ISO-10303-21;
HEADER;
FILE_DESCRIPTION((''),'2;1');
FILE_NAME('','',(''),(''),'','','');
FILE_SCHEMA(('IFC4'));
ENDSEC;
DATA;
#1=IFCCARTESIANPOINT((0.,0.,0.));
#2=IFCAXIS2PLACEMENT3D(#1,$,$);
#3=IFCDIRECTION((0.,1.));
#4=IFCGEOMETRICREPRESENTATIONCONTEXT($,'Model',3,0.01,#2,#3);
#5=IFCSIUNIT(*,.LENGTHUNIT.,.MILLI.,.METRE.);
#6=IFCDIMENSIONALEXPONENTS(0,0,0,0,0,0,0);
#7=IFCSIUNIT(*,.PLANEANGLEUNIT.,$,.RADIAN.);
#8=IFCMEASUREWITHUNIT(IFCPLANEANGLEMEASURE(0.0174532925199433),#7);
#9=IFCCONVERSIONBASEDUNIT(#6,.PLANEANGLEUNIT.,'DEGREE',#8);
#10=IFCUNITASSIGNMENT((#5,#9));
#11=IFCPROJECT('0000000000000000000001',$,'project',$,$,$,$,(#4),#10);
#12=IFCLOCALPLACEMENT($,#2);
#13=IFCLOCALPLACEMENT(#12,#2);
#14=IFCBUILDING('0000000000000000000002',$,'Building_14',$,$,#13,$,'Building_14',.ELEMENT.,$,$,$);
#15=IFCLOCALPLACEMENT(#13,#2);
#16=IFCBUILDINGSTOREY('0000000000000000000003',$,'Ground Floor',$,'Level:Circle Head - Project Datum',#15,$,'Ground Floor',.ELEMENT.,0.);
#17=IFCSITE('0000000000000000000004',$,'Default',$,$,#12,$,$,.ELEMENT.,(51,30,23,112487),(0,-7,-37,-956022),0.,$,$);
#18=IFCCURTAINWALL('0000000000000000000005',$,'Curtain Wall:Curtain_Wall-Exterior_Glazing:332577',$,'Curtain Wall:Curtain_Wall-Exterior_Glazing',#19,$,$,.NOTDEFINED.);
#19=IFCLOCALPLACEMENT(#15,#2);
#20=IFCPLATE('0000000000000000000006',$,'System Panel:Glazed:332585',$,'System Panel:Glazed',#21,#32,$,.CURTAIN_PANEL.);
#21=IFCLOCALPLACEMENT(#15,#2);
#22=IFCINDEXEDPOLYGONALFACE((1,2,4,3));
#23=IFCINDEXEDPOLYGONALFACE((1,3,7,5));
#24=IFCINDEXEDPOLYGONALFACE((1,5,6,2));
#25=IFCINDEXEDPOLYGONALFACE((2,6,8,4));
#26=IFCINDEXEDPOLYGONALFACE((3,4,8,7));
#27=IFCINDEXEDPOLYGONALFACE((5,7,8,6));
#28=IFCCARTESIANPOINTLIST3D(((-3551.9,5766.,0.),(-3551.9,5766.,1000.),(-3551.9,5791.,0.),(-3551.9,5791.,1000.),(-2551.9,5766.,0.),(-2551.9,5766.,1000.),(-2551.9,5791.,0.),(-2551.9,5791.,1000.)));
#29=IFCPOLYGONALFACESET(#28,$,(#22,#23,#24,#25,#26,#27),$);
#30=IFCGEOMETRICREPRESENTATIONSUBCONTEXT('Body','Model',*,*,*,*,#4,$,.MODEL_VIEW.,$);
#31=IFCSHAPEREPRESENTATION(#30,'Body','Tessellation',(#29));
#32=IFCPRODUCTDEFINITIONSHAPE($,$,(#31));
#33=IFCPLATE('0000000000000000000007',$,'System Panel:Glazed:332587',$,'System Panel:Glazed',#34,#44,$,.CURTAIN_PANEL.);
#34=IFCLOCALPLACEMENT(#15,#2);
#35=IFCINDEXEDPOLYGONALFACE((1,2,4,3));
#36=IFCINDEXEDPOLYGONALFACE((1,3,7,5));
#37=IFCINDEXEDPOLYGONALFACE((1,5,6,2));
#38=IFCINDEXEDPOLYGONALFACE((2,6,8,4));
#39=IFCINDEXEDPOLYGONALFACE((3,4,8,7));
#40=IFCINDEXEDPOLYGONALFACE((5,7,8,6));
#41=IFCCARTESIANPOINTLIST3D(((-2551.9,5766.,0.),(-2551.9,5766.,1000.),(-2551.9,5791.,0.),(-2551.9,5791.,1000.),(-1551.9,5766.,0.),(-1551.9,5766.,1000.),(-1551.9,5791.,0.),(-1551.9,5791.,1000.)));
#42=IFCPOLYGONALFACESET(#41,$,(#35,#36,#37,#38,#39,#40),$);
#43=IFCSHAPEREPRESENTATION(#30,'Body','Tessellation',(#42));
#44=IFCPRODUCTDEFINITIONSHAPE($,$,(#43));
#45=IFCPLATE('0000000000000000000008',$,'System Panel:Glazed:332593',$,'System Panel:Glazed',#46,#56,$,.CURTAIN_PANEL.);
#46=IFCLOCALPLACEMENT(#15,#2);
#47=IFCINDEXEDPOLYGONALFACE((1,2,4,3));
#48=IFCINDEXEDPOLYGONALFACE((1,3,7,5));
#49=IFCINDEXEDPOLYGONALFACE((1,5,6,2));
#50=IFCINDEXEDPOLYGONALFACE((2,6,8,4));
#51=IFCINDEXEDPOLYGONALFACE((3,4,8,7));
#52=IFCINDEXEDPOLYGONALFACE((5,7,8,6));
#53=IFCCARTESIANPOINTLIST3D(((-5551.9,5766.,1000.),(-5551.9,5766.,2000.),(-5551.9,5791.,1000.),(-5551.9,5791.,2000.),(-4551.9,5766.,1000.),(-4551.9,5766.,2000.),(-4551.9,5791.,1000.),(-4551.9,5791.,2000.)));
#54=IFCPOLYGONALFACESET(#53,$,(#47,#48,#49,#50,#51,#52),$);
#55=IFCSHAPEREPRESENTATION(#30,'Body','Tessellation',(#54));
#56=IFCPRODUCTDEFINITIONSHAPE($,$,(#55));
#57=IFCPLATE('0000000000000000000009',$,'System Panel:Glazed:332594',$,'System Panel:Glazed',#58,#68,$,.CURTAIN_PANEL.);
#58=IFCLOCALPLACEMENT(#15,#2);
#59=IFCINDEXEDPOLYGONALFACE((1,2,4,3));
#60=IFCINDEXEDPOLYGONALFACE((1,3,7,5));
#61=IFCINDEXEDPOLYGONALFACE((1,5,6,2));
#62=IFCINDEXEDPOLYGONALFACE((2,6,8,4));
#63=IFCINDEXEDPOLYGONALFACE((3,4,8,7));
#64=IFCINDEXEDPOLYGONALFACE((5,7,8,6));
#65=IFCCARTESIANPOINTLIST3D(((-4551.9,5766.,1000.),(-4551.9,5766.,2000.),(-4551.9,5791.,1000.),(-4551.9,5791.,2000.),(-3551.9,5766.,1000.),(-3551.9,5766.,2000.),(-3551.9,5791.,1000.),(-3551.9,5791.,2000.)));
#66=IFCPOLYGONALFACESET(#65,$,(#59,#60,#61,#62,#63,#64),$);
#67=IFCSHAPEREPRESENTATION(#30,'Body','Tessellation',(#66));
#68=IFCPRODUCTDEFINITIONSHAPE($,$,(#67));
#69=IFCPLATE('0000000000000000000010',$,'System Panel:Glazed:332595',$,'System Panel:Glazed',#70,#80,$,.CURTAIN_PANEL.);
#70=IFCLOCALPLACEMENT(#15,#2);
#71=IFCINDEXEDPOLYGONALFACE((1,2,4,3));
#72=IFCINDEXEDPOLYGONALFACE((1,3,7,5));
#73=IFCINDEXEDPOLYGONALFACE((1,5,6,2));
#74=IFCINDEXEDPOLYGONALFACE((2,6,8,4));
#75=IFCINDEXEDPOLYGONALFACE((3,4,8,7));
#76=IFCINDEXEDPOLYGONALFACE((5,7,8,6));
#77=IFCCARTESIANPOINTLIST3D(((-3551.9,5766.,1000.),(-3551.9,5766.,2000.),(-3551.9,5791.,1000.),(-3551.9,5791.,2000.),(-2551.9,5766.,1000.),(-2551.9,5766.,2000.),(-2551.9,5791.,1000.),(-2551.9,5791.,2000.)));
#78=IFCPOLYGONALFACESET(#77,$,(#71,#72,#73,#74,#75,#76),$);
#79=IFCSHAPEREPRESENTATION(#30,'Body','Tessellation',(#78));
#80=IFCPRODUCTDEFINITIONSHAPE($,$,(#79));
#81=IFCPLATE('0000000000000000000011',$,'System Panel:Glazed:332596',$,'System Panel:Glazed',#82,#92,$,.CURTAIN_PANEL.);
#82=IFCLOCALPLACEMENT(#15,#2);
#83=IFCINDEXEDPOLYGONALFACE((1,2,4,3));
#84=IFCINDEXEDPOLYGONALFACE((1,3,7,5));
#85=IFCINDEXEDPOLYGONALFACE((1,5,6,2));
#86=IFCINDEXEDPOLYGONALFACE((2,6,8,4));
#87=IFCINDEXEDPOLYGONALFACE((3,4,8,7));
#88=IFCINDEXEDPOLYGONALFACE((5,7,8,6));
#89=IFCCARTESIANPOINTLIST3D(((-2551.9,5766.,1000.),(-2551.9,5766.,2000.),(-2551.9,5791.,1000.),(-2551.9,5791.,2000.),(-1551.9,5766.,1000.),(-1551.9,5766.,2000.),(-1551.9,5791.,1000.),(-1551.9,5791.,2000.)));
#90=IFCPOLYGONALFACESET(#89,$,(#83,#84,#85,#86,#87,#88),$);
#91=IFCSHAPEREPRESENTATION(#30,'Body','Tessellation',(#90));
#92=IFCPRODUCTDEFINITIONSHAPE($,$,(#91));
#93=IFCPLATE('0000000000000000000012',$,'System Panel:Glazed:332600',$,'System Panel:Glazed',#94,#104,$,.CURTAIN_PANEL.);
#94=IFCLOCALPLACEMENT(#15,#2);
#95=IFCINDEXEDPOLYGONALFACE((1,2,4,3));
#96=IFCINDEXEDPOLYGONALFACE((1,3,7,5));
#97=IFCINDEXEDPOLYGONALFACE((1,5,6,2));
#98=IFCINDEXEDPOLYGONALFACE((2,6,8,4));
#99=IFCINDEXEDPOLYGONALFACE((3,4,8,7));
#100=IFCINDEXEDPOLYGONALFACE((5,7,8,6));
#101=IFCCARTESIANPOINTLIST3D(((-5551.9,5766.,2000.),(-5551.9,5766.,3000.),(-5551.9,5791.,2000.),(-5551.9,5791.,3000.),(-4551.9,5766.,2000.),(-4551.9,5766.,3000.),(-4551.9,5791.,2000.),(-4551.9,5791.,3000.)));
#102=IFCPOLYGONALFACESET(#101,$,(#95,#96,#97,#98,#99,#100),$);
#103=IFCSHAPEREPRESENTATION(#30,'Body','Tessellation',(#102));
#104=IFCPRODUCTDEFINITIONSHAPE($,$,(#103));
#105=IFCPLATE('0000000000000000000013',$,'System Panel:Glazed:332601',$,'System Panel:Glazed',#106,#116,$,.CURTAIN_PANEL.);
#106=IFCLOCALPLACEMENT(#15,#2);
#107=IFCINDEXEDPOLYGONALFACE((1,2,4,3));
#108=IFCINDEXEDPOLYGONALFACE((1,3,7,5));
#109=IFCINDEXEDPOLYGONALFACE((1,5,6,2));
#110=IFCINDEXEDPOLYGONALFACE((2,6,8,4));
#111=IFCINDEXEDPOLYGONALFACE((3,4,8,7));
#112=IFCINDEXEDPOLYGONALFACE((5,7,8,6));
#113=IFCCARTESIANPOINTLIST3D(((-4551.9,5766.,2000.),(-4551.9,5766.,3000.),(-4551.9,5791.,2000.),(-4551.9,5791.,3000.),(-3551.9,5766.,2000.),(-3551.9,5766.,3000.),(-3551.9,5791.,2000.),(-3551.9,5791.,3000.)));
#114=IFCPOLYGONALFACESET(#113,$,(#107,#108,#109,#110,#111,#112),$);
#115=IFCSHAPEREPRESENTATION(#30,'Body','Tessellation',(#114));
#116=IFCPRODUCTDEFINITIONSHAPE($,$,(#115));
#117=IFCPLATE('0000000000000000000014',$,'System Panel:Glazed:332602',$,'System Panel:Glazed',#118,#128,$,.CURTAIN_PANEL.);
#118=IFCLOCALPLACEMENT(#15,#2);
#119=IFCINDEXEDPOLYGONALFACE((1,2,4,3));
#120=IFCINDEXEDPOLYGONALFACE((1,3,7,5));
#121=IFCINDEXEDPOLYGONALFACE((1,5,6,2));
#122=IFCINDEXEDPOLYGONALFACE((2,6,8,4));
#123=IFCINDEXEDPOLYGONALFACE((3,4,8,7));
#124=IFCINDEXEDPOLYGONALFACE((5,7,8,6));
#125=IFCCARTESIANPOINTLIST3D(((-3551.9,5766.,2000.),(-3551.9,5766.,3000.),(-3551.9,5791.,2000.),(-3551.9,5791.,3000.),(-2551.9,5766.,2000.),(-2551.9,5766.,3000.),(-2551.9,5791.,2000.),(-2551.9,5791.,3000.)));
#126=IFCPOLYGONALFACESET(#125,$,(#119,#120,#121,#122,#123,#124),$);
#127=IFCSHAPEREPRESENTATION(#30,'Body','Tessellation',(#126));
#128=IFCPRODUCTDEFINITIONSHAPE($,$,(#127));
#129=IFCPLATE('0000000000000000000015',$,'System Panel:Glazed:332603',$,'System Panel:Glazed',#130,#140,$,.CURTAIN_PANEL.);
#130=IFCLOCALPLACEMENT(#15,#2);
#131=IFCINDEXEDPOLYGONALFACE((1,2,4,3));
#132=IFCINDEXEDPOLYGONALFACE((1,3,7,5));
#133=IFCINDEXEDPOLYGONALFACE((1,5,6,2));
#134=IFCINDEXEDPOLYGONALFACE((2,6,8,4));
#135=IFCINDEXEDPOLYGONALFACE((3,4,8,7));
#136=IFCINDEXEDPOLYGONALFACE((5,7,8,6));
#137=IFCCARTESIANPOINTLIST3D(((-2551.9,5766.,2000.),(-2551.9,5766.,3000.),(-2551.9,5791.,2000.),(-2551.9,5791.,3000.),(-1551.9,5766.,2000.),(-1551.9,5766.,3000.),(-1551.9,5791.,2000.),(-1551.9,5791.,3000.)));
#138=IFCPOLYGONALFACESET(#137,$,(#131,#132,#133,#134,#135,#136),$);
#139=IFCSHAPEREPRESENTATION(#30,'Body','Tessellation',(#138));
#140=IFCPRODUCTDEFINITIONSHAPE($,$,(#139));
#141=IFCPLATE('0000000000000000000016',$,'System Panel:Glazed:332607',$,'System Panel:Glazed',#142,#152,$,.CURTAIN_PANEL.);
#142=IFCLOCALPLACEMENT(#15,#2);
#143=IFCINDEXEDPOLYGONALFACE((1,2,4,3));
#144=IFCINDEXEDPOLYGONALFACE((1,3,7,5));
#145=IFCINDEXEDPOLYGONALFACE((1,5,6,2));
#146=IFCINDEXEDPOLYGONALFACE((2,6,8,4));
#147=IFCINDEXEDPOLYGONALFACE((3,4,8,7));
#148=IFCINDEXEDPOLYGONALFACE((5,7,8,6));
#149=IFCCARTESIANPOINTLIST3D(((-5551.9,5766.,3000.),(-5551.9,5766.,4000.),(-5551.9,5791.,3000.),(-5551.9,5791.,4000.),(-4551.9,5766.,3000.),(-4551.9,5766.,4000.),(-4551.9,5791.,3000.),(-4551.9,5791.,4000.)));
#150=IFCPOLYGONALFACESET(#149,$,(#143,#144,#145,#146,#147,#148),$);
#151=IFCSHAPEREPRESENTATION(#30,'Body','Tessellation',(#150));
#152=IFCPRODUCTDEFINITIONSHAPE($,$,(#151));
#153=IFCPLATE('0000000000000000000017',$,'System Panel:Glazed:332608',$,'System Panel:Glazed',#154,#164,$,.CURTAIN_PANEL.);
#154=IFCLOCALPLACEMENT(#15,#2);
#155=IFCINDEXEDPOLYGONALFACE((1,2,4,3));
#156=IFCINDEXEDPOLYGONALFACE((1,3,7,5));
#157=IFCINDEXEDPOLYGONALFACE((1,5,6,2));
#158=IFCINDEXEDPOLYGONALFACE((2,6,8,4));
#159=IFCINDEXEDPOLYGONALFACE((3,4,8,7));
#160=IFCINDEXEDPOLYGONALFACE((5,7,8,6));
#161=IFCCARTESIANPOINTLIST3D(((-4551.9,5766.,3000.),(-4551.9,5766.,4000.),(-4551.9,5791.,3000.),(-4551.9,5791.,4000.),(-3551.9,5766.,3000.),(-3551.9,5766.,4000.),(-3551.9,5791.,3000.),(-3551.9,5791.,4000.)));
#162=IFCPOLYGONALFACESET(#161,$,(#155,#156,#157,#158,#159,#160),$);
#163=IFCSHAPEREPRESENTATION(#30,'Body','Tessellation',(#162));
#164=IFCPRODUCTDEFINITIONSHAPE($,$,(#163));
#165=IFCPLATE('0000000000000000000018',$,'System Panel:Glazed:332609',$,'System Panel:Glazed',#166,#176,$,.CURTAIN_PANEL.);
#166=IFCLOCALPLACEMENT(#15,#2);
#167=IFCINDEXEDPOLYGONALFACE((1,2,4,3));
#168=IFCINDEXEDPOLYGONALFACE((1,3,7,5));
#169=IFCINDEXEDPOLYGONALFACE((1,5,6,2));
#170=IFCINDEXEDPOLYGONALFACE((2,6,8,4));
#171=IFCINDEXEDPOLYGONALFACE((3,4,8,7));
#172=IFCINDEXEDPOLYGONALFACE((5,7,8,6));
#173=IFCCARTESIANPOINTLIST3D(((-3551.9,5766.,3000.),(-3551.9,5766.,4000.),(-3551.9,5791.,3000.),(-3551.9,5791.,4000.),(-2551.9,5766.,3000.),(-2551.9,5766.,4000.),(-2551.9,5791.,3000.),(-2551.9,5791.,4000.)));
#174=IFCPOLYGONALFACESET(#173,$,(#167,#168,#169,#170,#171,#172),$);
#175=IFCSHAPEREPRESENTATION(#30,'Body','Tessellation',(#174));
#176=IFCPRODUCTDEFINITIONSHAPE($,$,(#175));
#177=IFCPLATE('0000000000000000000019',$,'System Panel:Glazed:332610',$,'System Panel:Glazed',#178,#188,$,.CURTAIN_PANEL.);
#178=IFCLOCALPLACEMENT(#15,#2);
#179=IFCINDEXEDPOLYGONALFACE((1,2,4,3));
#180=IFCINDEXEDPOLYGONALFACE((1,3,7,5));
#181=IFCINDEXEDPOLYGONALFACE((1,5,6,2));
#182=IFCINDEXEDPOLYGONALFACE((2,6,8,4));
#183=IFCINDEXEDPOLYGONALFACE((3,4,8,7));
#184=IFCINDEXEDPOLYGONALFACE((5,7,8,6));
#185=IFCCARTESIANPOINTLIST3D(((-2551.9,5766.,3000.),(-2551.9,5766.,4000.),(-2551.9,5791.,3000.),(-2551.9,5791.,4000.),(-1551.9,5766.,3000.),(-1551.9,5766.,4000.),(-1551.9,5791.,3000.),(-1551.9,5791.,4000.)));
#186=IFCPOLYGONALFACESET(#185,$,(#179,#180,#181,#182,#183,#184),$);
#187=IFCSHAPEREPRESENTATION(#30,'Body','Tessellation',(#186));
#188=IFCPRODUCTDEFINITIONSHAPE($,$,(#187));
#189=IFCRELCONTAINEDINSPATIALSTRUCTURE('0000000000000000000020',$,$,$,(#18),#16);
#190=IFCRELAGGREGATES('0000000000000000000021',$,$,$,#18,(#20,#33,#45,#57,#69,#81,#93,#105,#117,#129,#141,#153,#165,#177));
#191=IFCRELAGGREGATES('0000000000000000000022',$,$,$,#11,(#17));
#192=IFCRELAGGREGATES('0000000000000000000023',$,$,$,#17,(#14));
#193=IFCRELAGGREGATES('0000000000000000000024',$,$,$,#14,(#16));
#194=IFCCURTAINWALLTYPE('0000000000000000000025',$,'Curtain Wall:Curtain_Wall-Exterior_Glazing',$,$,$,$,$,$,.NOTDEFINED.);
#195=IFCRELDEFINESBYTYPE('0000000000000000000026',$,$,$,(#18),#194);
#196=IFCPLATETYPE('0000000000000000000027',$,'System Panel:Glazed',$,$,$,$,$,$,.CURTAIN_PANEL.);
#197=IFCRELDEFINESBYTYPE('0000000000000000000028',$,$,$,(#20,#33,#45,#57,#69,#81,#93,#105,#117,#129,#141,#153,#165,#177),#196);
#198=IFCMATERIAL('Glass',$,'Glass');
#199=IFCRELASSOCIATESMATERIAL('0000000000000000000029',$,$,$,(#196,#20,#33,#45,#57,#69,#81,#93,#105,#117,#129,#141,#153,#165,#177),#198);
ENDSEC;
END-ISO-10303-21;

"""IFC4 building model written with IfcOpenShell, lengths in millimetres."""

from ifc_helpers import new_model, entity, si_unit, converted_unit, direction, frame, origin, place, context, subcontext, project, spatial, indexed_curve, outline, extrude, source, transform, mapped, material, type_object, type_shapes, element, aggregate, save


model = new_model("IFC4")

# Units and contexts
model_context = context("Model", 3, precision=0.01, world=origin(), true_north=direction((0.0, 1.0)))
body_context = subcontext(model_context, "Body", "Model", "MODEL_VIEW")
ifc_project = project(units=[si_unit("LENGTHUNIT", "METRE", prefix="MILLI"), converted_unit("PLANEANGLEUNIT", "DEGREE", entity("IfcPlaneAngleMeasure", 0.0174532925199433), si_unit("PLANEANGLEUNIT", "RADIAN"), dimensions=[0, 0, 0, 0, 0, 0, 0])], contexts=[model_context])

# Site, building, storey
site_placement = place(None, origin())
site = spatial("IfcSite", under=ifc_project, at=site_placement, Name="Default", CompositionType="ELEMENT", RefLatitude=(51, 30, 23, 112487), RefLongitude=(0, -7, -37, -956022), RefElevation=0.0)
building_placement = place(site_placement, origin())
building = spatial("IfcBuilding", under=site, at=building_placement, Name="Building_14", LongName="Building_14", CompositionType="ELEMENT")
storey_placement = place(building_placement, origin())
storey = spatial("IfcBuildingStorey", under=building, at=storey_placement, Name="Ground Floor", ObjectType="Level:Circle Head - Project Datum", LongName="Ground Floor", CompositionType="ELEMENT", Elevation=0.0)

# Curtain wall, plates
curtain_wall_type = type_object("IfcCurtainWallType", Name="Curtain Wall:Curtain_Wall-Exterior_Glazing", PredefinedType="NOTDEFINED")
ifc_material = material(Name="Glass", Category="Glass")
plate_type_1 = type_object("IfcPlateType", Name="System Panel:Glazed", PredefinedType="CURTAIN_PANEL", material=ifc_material)
shared_shape_1 = source(origin(), body_context, "Body", "SweptSolid", [
    extrude(outline(indexed_curve([(-12.5, -500.0), (12.5, -500.0), (12.5, 500.0), (-12.5, 500.0), (-12.5, -500.0)], self_intersect=False)), frame((0.0, -37.0, 0.0), z_axis=(0.0, 0.0, 1.0), x_axis=(0.0, 1.0, 0.0)), (0.0, 0.0, 1.0), 1000.0),
])
type_shapes(plate_type_1, [shared_shape_1])
curtain_wall_1_placement = place(storey_placement, origin())
curtain_wall_1 = element("IfcCurtainWall", 1, at=curtain_wall_1_placement, inside=storey, type_object=curtain_wall_type, Name="Curtain Wall:Curtain_Wall-Exterior_Glazing:332577", ObjectType="Curtain Wall:Curtain_Wall-Exterior_Glazing", PredefinedType="NOTDEFINED")
plate_1_placement = place(curtain_wall_1_placement, frame((-3051.9, 5815.5, 0.0)))
plate_1 = element("IfcPlate", 2, at=plate_1_placement, type_object=plate_type_1, material=ifc_material, Name="System Panel:Glazed:332585", ObjectType="System Panel:Glazed", PredefinedType="CURTAIN_PANEL", context=body_context, shape_type="MappedRepresentation", body=[
    mapped(shared_shape_1, transform((0.0, 0.0, 0.0), scale=1.0)),
])
plate_2_placement = place(curtain_wall_1_placement, frame((-2051.9, 5815.5, 0.0)))
plate_2 = element("IfcPlate", 3, at=plate_2_placement, type_object=plate_type_1, material=ifc_material, Name="System Panel:Glazed:332587", ObjectType="System Panel:Glazed", PredefinedType="CURTAIN_PANEL", context=body_context, shape_type="MappedRepresentation", body=[
    mapped(shared_shape_1, transform((0.0, 0.0, 0.0), scale=1.0)),
])
plate_3_placement = place(curtain_wall_1_placement, frame((-5051.9, 5815.5, 1000.0)))
plate_3 = element("IfcPlate", 4, at=plate_3_placement, type_object=plate_type_1, material=ifc_material, Name="System Panel:Glazed:332593", ObjectType="System Panel:Glazed", PredefinedType="CURTAIN_PANEL", context=body_context, shape_type="MappedRepresentation", body=[
    mapped(shared_shape_1, transform((0.0, 0.0, 0.0), scale=1.0)),
])
plate_4_placement = place(curtain_wall_1_placement, frame((-4051.9, 5815.5, 1000.0)))
plate_4 = element("IfcPlate", 5, at=plate_4_placement, type_object=plate_type_1, material=ifc_material, Name="System Panel:Glazed:332594", ObjectType="System Panel:Glazed", PredefinedType="CURTAIN_PANEL", context=body_context, shape_type="MappedRepresentation", body=[
    mapped(shared_shape_1, transform((0.0, 0.0, 0.0), scale=1.0)),
])
plate_5_placement = place(curtain_wall_1_placement, frame((-3051.9, 5815.5, 1000.0)))
plate_5 = element("IfcPlate", 6, at=plate_5_placement, type_object=plate_type_1, material=ifc_material, Name="System Panel:Glazed:332595", ObjectType="System Panel:Glazed", PredefinedType="CURTAIN_PANEL", context=body_context, shape_type="MappedRepresentation", body=[
    mapped(shared_shape_1, transform((0.0, 0.0, 0.0), scale=1.0)),
])
plate_6_placement = place(curtain_wall_1_placement, frame((-2051.9, 5815.5, 1000.0)))
plate_6 = element("IfcPlate", 7, at=plate_6_placement, type_object=plate_type_1, material=ifc_material, Name="System Panel:Glazed:332596", ObjectType="System Panel:Glazed", PredefinedType="CURTAIN_PANEL", context=body_context, shape_type="MappedRepresentation", body=[
    mapped(shared_shape_1, transform((0.0, 0.0, 0.0), scale=1.0)),
])
plate_7_placement = place(curtain_wall_1_placement, frame((-5051.9, 5815.5, 2000.0)))
plate_7 = element("IfcPlate", 8, at=plate_7_placement, type_object=plate_type_1, material=ifc_material, Name="System Panel:Glazed:332600", ObjectType="System Panel:Glazed", PredefinedType="CURTAIN_PANEL", context=body_context, shape_type="MappedRepresentation", body=[
    mapped(shared_shape_1, transform((0.0, 0.0, 0.0), scale=1.0)),
])
plate_8_placement = place(curtain_wall_1_placement, frame((-4051.9, 5815.5, 2000.0)))
plate_8 = element("IfcPlate", 9, at=plate_8_placement, type_object=plate_type_1, material=ifc_material, Name="System Panel:Glazed:332601", ObjectType="System Panel:Glazed", PredefinedType="CURTAIN_PANEL", context=body_context, shape_type="MappedRepresentation", body=[
    mapped(shared_shape_1, transform((0.0, 0.0, 0.0), scale=1.0)),
])
plate_9_placement = place(curtain_wall_1_placement, frame((-3051.9, 5815.5, 2000.0)))
plate_9 = element("IfcPlate", 10, at=plate_9_placement, type_object=plate_type_1, material=ifc_material, Name="System Panel:Glazed:332602", ObjectType="System Panel:Glazed", PredefinedType="CURTAIN_PANEL", context=body_context, shape_type="MappedRepresentation", body=[
    mapped(shared_shape_1, transform((0.0, 0.0, 0.0), scale=1.0)),
])
plate_10_placement = place(curtain_wall_1_placement, frame((-2051.9, 5815.5, 2000.0)))
plate_10 = element("IfcPlate", 11, at=plate_10_placement, type_object=plate_type_1, material=ifc_material, Name="System Panel:Glazed:332603", ObjectType="System Panel:Glazed", PredefinedType="CURTAIN_PANEL", context=body_context, shape_type="MappedRepresentation", body=[
    mapped(shared_shape_1, transform((0.0, 0.0, 0.0), scale=1.0)),
])
plate_11_placement = place(curtain_wall_1_placement, frame((-5051.9, 5815.5, 3000.0)))
plate_11 = element("IfcPlate", 12, at=plate_11_placement, type_object=plate_type_1, material=ifc_material, Name="System Panel:Glazed:332607", ObjectType="System Panel:Glazed", PredefinedType="CURTAIN_PANEL", context=body_context, shape_type="MappedRepresentation", body=[
    mapped(shared_shape_1, transform((0.0, 0.0, 0.0), scale=1.0)),
])
plate_12_placement = place(curtain_wall_1_placement, frame((-4051.9, 5815.5, 3000.0)))
plate_12 = element("IfcPlate", 13, at=plate_12_placement, type_object=plate_type_1, material=ifc_material, Name="System Panel:Glazed:332608", ObjectType="System Panel:Glazed", PredefinedType="CURTAIN_PANEL", context=body_context, shape_type="MappedRepresentation", body=[
    mapped(shared_shape_1, transform((0.0, 0.0, 0.0), scale=1.0)),
])
plate_13_placement = place(curtain_wall_1_placement, frame((-3051.9, 5815.5, 3000.0)))
plate_13 = element("IfcPlate", 14, at=plate_13_placement, type_object=plate_type_1, material=ifc_material, Name="System Panel:Glazed:332609", ObjectType="System Panel:Glazed", PredefinedType="CURTAIN_PANEL", context=body_context, shape_type="MappedRepresentation", body=[
    mapped(shared_shape_1, transform((0.0, 0.0, 0.0), scale=1.0)),
])
plate_14_placement = place(curtain_wall_1_placement, frame((-2051.9, 5815.5, 3000.0)))
plate_14 = element("IfcPlate", 15, at=plate_14_placement, type_object=plate_type_1, material=ifc_material, Name="System Panel:Glazed:332610", ObjectType="System Panel:Glazed", PredefinedType="CURTAIN_PANEL", context=body_context, shape_type="MappedRepresentation", body=[
    mapped(shared_shape_1, transform((0.0, 0.0, 0.0), scale=1.0)),
])
aggregate(curtain_wall_1, [plate_1, plate_2, plate_3, plate_4, plate_5, plate_6, plate_7, plate_8, plate_9, plate_10, plate_11, plate_12, plate_13, plate_14])

save(model, "model.ifc")
